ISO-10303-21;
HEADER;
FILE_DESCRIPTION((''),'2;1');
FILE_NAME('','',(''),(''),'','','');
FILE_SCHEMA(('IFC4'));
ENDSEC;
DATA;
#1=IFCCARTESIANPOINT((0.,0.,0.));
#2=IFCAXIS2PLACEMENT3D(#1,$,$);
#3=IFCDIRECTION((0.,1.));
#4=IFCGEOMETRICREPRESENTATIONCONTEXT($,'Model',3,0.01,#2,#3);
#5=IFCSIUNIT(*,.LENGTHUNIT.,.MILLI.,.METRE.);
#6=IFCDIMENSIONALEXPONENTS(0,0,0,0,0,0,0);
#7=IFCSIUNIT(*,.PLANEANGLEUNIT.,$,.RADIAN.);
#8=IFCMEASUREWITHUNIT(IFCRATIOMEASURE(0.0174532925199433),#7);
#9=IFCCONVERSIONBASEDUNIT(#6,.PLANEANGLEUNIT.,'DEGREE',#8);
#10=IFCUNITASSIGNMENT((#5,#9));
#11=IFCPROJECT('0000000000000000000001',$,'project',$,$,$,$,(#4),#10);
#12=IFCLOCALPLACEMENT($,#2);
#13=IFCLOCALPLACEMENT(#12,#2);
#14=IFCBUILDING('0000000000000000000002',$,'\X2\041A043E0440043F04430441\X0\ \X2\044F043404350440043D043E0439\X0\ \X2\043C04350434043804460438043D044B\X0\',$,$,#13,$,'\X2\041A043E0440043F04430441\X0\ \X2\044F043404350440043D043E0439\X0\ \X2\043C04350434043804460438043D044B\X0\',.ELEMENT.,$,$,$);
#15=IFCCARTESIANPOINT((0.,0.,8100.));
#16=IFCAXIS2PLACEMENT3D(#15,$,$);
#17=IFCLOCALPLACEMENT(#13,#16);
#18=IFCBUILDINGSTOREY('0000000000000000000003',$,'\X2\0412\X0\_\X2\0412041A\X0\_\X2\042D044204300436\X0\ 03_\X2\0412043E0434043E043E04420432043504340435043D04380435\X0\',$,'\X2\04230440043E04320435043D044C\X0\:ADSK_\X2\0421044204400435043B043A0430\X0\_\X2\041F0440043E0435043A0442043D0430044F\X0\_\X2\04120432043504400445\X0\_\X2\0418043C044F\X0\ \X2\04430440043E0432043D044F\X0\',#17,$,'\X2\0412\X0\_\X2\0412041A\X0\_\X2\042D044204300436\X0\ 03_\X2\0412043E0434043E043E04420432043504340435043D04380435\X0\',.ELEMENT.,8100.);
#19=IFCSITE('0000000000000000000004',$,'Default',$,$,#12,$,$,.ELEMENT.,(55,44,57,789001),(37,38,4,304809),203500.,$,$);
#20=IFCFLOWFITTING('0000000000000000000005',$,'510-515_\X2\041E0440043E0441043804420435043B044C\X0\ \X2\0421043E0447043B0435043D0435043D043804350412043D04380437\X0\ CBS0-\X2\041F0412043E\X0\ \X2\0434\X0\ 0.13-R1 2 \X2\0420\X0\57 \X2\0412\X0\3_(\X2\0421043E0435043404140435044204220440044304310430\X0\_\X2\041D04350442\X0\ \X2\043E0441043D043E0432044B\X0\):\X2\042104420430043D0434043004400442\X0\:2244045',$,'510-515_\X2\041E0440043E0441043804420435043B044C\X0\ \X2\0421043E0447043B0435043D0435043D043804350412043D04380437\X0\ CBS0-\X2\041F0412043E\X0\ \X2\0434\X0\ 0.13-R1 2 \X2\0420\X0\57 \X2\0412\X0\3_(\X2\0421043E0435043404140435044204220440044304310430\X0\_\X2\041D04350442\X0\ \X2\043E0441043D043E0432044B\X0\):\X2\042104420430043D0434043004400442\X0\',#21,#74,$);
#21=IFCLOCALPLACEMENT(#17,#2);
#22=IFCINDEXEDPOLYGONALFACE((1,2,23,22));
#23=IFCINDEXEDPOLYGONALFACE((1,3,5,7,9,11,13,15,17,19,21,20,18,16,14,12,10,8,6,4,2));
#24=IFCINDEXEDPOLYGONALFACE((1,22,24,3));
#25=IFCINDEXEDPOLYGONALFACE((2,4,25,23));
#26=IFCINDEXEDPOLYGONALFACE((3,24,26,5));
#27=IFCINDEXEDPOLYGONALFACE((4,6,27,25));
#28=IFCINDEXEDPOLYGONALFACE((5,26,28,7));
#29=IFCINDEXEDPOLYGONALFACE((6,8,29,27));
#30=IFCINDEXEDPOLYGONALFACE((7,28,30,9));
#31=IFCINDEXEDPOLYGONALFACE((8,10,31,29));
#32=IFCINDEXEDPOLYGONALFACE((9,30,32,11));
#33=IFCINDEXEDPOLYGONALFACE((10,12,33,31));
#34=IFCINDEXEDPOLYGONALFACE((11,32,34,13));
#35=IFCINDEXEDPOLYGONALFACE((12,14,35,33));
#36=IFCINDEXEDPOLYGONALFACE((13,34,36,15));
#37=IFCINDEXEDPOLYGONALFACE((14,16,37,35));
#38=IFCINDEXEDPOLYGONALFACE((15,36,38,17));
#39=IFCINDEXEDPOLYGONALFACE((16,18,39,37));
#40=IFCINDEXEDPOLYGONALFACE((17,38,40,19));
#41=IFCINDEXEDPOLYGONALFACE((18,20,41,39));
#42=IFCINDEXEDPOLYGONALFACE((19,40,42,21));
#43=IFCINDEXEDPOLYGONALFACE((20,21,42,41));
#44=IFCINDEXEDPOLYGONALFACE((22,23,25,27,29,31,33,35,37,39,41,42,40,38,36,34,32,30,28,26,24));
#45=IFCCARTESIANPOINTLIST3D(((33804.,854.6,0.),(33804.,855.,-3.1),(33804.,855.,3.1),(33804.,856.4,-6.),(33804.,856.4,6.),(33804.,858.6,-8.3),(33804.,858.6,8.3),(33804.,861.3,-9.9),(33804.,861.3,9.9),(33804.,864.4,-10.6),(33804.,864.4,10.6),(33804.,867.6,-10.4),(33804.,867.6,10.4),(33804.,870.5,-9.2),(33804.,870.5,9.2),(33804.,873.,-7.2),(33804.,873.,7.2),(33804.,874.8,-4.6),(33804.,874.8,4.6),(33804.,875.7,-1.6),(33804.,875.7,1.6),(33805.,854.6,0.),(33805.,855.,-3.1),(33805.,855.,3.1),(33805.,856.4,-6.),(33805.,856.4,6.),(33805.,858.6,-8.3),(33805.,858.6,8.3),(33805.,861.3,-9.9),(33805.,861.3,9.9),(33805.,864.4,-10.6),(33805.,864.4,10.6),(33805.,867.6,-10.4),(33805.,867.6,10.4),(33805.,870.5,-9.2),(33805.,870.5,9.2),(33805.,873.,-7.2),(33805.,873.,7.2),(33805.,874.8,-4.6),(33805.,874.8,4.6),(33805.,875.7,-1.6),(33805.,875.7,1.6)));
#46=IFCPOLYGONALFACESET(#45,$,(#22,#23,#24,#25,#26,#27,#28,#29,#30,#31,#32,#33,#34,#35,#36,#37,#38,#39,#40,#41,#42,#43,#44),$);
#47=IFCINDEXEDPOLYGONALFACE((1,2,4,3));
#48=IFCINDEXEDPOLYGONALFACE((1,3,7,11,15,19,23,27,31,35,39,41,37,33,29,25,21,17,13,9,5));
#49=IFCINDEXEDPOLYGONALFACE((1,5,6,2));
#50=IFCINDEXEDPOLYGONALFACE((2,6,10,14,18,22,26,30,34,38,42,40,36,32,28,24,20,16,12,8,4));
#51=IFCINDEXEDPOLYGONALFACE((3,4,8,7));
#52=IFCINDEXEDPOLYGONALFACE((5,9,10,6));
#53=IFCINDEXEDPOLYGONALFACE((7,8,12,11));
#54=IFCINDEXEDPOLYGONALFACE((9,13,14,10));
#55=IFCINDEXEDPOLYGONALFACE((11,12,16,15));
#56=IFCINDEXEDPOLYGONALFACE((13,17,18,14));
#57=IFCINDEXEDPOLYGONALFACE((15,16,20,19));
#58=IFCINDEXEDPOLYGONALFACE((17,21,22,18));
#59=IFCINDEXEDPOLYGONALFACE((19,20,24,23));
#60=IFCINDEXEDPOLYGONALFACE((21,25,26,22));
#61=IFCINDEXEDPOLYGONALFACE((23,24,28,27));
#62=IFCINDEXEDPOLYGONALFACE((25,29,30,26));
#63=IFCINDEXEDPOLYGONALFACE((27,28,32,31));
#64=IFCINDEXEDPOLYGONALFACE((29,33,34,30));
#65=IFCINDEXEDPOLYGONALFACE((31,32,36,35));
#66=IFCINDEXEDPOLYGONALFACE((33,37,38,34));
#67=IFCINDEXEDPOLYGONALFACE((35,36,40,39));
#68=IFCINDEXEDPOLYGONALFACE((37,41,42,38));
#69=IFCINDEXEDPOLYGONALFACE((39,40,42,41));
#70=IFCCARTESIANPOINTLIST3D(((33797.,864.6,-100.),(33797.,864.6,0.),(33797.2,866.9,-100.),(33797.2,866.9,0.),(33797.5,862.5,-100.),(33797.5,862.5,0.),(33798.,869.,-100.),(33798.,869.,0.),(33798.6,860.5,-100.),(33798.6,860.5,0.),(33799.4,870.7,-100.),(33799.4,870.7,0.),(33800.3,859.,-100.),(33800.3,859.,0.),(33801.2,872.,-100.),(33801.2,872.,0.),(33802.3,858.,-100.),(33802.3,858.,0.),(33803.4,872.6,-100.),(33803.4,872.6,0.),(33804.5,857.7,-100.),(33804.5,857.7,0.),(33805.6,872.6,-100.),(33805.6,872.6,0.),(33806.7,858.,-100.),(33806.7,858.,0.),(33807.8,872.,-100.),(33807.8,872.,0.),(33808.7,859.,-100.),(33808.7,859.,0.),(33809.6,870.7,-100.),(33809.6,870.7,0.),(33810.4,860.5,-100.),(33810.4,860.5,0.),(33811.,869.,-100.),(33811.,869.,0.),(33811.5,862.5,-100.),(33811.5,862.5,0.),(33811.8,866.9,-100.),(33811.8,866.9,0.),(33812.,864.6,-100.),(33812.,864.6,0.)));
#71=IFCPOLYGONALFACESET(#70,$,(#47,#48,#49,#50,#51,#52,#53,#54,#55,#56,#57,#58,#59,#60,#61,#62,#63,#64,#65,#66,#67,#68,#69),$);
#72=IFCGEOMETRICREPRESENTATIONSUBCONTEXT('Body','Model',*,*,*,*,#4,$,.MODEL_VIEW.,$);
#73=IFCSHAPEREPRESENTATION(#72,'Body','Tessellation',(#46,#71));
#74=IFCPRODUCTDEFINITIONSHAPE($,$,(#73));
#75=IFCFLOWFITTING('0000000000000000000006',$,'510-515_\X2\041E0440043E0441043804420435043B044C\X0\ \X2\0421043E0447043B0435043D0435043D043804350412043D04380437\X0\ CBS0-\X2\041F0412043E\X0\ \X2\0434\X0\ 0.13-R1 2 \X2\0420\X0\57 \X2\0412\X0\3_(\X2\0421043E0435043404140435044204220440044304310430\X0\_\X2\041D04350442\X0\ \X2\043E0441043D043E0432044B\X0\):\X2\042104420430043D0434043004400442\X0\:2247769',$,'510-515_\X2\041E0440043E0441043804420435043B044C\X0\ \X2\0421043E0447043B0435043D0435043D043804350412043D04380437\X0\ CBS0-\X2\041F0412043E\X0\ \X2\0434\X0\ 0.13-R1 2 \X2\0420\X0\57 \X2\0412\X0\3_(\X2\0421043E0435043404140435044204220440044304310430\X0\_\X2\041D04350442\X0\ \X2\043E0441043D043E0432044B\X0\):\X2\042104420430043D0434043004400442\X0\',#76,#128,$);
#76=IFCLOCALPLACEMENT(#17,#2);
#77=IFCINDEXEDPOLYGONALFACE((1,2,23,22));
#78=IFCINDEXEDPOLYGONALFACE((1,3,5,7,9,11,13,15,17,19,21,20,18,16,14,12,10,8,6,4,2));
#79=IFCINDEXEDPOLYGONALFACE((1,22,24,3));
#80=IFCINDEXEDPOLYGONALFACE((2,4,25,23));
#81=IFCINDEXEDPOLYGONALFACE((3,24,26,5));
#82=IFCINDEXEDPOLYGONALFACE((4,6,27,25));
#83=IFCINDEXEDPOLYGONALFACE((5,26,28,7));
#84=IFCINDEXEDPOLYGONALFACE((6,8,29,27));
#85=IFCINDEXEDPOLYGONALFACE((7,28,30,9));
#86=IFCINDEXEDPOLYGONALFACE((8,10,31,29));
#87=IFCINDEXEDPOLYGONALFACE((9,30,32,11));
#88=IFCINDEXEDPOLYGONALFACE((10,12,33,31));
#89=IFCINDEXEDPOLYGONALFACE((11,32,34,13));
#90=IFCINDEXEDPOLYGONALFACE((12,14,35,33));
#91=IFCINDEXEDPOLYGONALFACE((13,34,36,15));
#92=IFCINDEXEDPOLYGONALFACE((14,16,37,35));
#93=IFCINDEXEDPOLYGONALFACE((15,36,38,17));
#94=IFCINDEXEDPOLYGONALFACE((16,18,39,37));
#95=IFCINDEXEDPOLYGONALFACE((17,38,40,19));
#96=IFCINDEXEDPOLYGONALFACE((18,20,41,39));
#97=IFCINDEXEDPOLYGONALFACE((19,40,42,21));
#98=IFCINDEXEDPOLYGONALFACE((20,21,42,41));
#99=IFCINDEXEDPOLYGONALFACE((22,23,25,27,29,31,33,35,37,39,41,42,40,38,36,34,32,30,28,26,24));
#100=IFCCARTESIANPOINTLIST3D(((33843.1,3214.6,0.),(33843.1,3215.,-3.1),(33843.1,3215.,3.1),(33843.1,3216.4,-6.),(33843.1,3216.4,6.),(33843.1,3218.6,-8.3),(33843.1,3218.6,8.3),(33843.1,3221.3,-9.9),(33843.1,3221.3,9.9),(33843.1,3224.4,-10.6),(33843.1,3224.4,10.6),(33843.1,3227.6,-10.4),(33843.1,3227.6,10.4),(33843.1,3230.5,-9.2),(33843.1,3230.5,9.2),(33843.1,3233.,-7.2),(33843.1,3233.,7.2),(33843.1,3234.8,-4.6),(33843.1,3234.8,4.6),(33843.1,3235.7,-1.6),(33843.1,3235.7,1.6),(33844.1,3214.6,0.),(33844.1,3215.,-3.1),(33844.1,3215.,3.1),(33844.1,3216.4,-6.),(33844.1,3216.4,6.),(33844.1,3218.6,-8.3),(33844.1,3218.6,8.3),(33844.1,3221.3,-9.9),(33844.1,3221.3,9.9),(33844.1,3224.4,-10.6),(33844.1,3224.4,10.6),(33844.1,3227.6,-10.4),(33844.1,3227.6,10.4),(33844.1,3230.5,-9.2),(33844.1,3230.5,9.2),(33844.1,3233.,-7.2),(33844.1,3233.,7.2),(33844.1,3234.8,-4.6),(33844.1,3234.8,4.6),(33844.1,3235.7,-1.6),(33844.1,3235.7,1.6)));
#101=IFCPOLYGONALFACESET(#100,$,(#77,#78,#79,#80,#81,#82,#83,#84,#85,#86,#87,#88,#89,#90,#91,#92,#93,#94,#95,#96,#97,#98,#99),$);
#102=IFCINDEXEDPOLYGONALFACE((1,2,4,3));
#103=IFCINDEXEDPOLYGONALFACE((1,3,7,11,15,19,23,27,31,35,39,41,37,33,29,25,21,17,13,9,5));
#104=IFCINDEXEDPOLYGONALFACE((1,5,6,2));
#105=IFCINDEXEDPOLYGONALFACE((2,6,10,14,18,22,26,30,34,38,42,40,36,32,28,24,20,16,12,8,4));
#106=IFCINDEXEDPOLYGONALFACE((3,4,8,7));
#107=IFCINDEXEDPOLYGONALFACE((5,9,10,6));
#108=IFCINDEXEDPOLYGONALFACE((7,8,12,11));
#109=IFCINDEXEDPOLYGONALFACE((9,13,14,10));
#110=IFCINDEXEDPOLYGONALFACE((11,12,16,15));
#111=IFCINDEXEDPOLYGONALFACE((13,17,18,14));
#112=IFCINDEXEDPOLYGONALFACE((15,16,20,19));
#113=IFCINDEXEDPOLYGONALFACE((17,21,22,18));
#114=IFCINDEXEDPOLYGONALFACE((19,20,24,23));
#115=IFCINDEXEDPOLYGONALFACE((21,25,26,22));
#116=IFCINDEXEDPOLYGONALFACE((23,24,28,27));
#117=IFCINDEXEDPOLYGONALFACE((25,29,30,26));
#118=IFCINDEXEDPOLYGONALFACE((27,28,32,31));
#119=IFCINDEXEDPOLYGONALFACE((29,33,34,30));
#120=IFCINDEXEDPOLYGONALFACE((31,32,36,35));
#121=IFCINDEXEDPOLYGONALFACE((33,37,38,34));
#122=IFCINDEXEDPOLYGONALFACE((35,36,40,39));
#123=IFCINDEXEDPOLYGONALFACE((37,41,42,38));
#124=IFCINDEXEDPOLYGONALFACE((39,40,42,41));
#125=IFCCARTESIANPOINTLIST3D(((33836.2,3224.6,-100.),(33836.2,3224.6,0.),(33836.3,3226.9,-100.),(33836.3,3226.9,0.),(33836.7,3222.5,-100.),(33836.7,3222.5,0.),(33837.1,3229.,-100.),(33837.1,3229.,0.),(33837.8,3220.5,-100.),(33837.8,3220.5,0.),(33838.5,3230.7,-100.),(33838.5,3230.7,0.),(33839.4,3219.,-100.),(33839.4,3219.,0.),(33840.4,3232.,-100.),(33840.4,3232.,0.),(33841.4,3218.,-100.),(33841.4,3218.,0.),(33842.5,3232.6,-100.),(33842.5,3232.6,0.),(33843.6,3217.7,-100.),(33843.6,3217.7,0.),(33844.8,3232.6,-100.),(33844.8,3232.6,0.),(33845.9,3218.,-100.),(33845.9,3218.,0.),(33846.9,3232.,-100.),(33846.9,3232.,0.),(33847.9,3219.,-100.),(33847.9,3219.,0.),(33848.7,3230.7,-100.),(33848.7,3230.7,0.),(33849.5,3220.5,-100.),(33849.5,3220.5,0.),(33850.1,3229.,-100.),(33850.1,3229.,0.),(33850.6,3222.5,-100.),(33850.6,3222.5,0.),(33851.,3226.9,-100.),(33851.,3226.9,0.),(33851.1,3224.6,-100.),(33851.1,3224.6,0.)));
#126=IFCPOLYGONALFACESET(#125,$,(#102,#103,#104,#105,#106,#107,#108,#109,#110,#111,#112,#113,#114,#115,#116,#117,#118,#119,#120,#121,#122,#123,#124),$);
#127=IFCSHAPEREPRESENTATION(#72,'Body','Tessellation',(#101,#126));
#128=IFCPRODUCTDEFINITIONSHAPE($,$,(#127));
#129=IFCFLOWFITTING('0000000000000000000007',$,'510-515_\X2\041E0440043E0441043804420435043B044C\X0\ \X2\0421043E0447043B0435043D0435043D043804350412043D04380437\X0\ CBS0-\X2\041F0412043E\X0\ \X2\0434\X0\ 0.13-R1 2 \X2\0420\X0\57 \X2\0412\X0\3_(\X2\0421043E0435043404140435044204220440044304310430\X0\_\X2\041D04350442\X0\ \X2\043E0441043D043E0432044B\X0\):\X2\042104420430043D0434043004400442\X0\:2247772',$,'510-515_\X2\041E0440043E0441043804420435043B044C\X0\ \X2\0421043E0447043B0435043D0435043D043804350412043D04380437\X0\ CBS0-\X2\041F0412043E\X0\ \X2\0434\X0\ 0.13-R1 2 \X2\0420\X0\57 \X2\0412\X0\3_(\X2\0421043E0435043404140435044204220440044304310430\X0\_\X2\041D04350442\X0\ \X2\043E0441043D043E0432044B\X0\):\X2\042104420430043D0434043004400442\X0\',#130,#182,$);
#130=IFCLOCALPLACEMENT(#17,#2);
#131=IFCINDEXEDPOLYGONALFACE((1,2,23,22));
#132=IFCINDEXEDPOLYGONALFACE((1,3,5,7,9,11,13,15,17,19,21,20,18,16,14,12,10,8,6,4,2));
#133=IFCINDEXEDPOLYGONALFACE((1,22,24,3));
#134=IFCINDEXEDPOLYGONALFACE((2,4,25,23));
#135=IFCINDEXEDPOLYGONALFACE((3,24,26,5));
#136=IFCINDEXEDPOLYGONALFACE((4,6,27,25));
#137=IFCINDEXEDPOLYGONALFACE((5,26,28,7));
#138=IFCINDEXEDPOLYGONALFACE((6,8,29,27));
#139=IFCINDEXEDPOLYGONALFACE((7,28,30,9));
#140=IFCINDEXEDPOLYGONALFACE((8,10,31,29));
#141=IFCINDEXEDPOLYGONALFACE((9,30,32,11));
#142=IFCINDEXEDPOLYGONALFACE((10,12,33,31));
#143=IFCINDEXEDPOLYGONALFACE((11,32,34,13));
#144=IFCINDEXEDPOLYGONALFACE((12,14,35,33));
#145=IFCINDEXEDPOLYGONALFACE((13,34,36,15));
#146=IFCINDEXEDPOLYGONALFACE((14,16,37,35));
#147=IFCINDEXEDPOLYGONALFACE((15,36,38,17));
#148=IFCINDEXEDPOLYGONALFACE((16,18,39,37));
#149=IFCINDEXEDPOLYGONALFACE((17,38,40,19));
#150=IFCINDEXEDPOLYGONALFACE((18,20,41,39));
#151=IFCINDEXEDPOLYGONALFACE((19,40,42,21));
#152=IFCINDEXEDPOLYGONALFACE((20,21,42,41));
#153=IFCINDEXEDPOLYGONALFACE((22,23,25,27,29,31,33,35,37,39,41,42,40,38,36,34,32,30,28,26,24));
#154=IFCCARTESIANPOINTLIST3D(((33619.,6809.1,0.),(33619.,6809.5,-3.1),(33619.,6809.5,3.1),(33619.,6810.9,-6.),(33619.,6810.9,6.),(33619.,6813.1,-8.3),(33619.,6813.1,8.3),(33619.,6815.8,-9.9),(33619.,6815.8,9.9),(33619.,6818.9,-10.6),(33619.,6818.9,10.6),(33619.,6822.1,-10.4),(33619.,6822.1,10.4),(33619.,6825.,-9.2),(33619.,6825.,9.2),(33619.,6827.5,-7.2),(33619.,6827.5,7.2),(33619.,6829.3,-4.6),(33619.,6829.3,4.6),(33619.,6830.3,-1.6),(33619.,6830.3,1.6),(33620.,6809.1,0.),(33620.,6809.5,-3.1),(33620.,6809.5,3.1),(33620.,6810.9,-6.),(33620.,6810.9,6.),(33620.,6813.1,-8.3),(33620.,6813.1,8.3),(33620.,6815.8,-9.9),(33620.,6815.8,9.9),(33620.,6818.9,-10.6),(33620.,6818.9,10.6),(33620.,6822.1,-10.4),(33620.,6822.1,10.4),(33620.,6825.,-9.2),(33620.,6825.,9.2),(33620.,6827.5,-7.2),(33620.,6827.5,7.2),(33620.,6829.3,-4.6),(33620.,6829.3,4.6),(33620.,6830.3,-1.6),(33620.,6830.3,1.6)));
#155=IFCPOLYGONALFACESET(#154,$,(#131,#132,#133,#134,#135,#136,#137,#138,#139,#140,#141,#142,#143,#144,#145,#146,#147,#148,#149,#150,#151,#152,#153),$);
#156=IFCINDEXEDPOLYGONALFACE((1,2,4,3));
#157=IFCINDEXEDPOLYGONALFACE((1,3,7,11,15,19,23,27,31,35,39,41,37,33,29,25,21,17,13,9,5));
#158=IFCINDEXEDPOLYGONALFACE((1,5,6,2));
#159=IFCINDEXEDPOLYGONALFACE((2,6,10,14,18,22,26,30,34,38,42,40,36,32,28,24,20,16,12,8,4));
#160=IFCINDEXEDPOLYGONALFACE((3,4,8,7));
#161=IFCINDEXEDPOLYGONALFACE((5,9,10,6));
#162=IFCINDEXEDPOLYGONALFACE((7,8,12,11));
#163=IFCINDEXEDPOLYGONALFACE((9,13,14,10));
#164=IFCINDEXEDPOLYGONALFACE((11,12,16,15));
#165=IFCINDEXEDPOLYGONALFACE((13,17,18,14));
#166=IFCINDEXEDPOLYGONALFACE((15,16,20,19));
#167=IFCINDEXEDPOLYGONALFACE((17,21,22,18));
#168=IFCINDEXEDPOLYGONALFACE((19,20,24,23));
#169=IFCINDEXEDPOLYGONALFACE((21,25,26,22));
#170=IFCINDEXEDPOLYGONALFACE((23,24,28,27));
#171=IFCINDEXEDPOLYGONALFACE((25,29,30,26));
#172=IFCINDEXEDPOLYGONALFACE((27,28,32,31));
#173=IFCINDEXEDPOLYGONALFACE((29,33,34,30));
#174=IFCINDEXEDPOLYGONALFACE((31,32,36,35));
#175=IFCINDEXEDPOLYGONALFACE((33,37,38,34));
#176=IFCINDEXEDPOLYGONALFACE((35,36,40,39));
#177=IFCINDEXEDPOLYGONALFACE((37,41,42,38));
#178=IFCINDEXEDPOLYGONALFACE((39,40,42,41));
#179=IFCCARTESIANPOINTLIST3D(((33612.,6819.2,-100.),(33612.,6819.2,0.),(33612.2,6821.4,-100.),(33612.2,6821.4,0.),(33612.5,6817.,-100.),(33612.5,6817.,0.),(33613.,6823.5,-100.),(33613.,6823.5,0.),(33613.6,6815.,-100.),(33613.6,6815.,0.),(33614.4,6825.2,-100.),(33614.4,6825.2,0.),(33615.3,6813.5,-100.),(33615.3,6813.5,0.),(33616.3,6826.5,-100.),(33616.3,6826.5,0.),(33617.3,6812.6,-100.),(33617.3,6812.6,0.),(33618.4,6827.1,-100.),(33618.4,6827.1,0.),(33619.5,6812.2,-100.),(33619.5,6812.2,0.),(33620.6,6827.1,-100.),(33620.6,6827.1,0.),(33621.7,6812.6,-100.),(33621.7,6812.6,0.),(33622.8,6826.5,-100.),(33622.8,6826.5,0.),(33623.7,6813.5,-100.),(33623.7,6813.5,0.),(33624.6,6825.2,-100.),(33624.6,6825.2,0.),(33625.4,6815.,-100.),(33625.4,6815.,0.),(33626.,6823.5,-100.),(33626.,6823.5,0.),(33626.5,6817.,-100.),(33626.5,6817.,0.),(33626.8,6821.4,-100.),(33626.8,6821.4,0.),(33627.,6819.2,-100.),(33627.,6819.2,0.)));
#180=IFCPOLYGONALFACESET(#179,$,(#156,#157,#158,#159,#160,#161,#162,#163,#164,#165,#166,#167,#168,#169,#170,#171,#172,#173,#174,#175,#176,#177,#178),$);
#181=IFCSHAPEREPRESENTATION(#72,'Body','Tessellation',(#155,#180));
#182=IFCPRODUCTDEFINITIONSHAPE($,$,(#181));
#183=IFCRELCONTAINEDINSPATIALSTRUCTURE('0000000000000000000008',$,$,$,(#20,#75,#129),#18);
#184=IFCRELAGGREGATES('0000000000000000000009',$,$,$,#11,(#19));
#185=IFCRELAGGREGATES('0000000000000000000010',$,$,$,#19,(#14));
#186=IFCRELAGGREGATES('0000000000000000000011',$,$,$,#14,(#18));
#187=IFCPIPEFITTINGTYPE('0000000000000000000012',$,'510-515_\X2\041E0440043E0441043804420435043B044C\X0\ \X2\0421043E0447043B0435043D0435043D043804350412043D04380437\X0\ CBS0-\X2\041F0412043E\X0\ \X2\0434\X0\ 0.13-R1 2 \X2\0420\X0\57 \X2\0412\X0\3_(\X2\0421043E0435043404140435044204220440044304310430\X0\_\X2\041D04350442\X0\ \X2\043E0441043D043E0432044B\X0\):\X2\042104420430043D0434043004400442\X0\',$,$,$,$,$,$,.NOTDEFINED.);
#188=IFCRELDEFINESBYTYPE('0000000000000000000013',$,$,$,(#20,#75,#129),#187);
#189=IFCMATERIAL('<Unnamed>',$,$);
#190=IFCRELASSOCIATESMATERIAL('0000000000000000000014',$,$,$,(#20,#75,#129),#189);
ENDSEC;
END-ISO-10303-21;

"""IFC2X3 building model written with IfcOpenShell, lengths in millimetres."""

from ifc_helpers import new_model, entity, si_unit, converted_unit, direction, frame, origin, origin_2d_with_axis, place, context, subcontext, project, spatial, circle, extrude, source, transform, mapped, material, type_object, type_shapes, element, save


model = new_model("IFC2X3")

# Units and contexts
model_context = context("Model", 3, precision=0.01, world=origin(), true_north=direction((0.0, 1.0)))
body_context = subcontext(model_context, "Body", "Model", "MODEL_VIEW")
ifc_project = project(units=[si_unit("LENGTHUNIT", "METRE", prefix="MILLI"), converted_unit("PLANEANGLEUNIT", "DEGREE", entity("IfcRatioMeasure", 0.0174532925199433), si_unit("PLANEANGLEUNIT", "RADIAN"), dimensions=[0, 0, 0, 0, 0, 0, 0])], contexts=[model_context])

# Site, building, storey
site_placement = place(None, origin())
site = spatial("IfcSite", under=ifc_project, at=site_placement, Name="Default", CompositionType="ELEMENT", RefLatitude=(55, 44, 57, 789001), RefLongitude=(37, 38, 4, 304809), RefElevation=203500.0)
building_placement = place(site_placement, origin())
building = spatial("IfcBuilding", under=site, at=building_placement, Name="Корпус ядерной медицины", LongName="Корпус ядерной медицины", CompositionType="ELEMENT")
storey_placement = place(building_placement, frame((0.0, 0.0, 8100.0)))
storey = spatial("IfcBuildingStorey", under=building, at=storey_placement, Name="В_ВК_Этаж 03_Водоотведение", ObjectType="Уровень:ADSK_Стрелка_Проектная_Вверх_Имя уровня", LongName="В_ВК_Этаж 03_Водоотведение", CompositionType="ELEMENT", Elevation=8100.0)

# Flow fittings
ifc_material = material(Name="<Unnamed>")
pipe_fitting_type = type_object("IfcPipeFittingType", Name="510-515_Ороситель СочленениеВниз CBS0-ПВо д 0.13-R1 2 Р57 В3_(СоедДетТруба_Нет основы):Стандарт", PredefinedType="NOTDEFINED")
shared_shape = source(origin(), body_context, "Body", "SweptSolid", [
    extrude(circle(Radius=10.7, at=origin_2d_with_axis()), frame((-0.5, 0.0, 0.0), z_axis=(1.0, 0.0, 0.0), x_axis=(0.0, 1.0, 0.0)), (0.0, 0.0, 1.0), 1.0),
    extrude(circle(Radius=7.5, at=origin_2d_with_axis()), frame((0.0, 0.0, -100.0), z_axis=(0.0, 0.0, 1.0), x_axis=(0.0, 1.0, 0.0)), (0.0, 0.0, 1.0), 100.0),
])
type_shapes(pipe_fitting_type, [shared_shape])
for number, where, z_axis, x_axis, name in (
    (1, (33804.5, 865.2, 0.0), (0.0, 0.0, 1.0), (-1.0, 0.0, 0.0), "510-515_Ороситель СочленениеВниз CBS0-ПВо д 0.13-R1 2 Р57 В3_(СоедДетТруба_Нет основы):Стандарт:2244045"),
    (2, (33843.6, 3225.2, 0.0), (0.0, 0.0, 1.0), (-1.0, 0.0, 0.0), "510-515_Ороситель СочленениеВниз CBS0-ПВо д 0.13-R1 2 Р57 В3_(СоедДетТруба_Нет основы):Стандарт:2247769"),
    (3, (33619.5, 6819.7, 0.0), (0.0, 0.0, 1.0), (-1.0, 0.0, 0.0), "510-515_Ороситель СочленениеВниз CBS0-ПВо д 0.13-R1 2 Р57 В3_(СоедДетТруба_Нет основы):Стандарт:2247772"),
):
    element("IfcFlowFitting", number, at=place(storey_placement, frame(where, z_axis=z_axis, x_axis=x_axis)), inside=storey, type_object=pipe_fitting_type, material=ifc_material, Name=name, ObjectType="510-515_Ороситель СочленениеВниз CBS0-ПВо д 0.13-R1 2 Р57 В3_(СоедДетТруба_Нет основы):Стандарт", context=body_context, shape_type="MappedRepresentation", body=[
        mapped(shared_shape, transform((0.0, 0.0, 0.0), scale=1.0)),
    ])

save(model, "model.ifc")
